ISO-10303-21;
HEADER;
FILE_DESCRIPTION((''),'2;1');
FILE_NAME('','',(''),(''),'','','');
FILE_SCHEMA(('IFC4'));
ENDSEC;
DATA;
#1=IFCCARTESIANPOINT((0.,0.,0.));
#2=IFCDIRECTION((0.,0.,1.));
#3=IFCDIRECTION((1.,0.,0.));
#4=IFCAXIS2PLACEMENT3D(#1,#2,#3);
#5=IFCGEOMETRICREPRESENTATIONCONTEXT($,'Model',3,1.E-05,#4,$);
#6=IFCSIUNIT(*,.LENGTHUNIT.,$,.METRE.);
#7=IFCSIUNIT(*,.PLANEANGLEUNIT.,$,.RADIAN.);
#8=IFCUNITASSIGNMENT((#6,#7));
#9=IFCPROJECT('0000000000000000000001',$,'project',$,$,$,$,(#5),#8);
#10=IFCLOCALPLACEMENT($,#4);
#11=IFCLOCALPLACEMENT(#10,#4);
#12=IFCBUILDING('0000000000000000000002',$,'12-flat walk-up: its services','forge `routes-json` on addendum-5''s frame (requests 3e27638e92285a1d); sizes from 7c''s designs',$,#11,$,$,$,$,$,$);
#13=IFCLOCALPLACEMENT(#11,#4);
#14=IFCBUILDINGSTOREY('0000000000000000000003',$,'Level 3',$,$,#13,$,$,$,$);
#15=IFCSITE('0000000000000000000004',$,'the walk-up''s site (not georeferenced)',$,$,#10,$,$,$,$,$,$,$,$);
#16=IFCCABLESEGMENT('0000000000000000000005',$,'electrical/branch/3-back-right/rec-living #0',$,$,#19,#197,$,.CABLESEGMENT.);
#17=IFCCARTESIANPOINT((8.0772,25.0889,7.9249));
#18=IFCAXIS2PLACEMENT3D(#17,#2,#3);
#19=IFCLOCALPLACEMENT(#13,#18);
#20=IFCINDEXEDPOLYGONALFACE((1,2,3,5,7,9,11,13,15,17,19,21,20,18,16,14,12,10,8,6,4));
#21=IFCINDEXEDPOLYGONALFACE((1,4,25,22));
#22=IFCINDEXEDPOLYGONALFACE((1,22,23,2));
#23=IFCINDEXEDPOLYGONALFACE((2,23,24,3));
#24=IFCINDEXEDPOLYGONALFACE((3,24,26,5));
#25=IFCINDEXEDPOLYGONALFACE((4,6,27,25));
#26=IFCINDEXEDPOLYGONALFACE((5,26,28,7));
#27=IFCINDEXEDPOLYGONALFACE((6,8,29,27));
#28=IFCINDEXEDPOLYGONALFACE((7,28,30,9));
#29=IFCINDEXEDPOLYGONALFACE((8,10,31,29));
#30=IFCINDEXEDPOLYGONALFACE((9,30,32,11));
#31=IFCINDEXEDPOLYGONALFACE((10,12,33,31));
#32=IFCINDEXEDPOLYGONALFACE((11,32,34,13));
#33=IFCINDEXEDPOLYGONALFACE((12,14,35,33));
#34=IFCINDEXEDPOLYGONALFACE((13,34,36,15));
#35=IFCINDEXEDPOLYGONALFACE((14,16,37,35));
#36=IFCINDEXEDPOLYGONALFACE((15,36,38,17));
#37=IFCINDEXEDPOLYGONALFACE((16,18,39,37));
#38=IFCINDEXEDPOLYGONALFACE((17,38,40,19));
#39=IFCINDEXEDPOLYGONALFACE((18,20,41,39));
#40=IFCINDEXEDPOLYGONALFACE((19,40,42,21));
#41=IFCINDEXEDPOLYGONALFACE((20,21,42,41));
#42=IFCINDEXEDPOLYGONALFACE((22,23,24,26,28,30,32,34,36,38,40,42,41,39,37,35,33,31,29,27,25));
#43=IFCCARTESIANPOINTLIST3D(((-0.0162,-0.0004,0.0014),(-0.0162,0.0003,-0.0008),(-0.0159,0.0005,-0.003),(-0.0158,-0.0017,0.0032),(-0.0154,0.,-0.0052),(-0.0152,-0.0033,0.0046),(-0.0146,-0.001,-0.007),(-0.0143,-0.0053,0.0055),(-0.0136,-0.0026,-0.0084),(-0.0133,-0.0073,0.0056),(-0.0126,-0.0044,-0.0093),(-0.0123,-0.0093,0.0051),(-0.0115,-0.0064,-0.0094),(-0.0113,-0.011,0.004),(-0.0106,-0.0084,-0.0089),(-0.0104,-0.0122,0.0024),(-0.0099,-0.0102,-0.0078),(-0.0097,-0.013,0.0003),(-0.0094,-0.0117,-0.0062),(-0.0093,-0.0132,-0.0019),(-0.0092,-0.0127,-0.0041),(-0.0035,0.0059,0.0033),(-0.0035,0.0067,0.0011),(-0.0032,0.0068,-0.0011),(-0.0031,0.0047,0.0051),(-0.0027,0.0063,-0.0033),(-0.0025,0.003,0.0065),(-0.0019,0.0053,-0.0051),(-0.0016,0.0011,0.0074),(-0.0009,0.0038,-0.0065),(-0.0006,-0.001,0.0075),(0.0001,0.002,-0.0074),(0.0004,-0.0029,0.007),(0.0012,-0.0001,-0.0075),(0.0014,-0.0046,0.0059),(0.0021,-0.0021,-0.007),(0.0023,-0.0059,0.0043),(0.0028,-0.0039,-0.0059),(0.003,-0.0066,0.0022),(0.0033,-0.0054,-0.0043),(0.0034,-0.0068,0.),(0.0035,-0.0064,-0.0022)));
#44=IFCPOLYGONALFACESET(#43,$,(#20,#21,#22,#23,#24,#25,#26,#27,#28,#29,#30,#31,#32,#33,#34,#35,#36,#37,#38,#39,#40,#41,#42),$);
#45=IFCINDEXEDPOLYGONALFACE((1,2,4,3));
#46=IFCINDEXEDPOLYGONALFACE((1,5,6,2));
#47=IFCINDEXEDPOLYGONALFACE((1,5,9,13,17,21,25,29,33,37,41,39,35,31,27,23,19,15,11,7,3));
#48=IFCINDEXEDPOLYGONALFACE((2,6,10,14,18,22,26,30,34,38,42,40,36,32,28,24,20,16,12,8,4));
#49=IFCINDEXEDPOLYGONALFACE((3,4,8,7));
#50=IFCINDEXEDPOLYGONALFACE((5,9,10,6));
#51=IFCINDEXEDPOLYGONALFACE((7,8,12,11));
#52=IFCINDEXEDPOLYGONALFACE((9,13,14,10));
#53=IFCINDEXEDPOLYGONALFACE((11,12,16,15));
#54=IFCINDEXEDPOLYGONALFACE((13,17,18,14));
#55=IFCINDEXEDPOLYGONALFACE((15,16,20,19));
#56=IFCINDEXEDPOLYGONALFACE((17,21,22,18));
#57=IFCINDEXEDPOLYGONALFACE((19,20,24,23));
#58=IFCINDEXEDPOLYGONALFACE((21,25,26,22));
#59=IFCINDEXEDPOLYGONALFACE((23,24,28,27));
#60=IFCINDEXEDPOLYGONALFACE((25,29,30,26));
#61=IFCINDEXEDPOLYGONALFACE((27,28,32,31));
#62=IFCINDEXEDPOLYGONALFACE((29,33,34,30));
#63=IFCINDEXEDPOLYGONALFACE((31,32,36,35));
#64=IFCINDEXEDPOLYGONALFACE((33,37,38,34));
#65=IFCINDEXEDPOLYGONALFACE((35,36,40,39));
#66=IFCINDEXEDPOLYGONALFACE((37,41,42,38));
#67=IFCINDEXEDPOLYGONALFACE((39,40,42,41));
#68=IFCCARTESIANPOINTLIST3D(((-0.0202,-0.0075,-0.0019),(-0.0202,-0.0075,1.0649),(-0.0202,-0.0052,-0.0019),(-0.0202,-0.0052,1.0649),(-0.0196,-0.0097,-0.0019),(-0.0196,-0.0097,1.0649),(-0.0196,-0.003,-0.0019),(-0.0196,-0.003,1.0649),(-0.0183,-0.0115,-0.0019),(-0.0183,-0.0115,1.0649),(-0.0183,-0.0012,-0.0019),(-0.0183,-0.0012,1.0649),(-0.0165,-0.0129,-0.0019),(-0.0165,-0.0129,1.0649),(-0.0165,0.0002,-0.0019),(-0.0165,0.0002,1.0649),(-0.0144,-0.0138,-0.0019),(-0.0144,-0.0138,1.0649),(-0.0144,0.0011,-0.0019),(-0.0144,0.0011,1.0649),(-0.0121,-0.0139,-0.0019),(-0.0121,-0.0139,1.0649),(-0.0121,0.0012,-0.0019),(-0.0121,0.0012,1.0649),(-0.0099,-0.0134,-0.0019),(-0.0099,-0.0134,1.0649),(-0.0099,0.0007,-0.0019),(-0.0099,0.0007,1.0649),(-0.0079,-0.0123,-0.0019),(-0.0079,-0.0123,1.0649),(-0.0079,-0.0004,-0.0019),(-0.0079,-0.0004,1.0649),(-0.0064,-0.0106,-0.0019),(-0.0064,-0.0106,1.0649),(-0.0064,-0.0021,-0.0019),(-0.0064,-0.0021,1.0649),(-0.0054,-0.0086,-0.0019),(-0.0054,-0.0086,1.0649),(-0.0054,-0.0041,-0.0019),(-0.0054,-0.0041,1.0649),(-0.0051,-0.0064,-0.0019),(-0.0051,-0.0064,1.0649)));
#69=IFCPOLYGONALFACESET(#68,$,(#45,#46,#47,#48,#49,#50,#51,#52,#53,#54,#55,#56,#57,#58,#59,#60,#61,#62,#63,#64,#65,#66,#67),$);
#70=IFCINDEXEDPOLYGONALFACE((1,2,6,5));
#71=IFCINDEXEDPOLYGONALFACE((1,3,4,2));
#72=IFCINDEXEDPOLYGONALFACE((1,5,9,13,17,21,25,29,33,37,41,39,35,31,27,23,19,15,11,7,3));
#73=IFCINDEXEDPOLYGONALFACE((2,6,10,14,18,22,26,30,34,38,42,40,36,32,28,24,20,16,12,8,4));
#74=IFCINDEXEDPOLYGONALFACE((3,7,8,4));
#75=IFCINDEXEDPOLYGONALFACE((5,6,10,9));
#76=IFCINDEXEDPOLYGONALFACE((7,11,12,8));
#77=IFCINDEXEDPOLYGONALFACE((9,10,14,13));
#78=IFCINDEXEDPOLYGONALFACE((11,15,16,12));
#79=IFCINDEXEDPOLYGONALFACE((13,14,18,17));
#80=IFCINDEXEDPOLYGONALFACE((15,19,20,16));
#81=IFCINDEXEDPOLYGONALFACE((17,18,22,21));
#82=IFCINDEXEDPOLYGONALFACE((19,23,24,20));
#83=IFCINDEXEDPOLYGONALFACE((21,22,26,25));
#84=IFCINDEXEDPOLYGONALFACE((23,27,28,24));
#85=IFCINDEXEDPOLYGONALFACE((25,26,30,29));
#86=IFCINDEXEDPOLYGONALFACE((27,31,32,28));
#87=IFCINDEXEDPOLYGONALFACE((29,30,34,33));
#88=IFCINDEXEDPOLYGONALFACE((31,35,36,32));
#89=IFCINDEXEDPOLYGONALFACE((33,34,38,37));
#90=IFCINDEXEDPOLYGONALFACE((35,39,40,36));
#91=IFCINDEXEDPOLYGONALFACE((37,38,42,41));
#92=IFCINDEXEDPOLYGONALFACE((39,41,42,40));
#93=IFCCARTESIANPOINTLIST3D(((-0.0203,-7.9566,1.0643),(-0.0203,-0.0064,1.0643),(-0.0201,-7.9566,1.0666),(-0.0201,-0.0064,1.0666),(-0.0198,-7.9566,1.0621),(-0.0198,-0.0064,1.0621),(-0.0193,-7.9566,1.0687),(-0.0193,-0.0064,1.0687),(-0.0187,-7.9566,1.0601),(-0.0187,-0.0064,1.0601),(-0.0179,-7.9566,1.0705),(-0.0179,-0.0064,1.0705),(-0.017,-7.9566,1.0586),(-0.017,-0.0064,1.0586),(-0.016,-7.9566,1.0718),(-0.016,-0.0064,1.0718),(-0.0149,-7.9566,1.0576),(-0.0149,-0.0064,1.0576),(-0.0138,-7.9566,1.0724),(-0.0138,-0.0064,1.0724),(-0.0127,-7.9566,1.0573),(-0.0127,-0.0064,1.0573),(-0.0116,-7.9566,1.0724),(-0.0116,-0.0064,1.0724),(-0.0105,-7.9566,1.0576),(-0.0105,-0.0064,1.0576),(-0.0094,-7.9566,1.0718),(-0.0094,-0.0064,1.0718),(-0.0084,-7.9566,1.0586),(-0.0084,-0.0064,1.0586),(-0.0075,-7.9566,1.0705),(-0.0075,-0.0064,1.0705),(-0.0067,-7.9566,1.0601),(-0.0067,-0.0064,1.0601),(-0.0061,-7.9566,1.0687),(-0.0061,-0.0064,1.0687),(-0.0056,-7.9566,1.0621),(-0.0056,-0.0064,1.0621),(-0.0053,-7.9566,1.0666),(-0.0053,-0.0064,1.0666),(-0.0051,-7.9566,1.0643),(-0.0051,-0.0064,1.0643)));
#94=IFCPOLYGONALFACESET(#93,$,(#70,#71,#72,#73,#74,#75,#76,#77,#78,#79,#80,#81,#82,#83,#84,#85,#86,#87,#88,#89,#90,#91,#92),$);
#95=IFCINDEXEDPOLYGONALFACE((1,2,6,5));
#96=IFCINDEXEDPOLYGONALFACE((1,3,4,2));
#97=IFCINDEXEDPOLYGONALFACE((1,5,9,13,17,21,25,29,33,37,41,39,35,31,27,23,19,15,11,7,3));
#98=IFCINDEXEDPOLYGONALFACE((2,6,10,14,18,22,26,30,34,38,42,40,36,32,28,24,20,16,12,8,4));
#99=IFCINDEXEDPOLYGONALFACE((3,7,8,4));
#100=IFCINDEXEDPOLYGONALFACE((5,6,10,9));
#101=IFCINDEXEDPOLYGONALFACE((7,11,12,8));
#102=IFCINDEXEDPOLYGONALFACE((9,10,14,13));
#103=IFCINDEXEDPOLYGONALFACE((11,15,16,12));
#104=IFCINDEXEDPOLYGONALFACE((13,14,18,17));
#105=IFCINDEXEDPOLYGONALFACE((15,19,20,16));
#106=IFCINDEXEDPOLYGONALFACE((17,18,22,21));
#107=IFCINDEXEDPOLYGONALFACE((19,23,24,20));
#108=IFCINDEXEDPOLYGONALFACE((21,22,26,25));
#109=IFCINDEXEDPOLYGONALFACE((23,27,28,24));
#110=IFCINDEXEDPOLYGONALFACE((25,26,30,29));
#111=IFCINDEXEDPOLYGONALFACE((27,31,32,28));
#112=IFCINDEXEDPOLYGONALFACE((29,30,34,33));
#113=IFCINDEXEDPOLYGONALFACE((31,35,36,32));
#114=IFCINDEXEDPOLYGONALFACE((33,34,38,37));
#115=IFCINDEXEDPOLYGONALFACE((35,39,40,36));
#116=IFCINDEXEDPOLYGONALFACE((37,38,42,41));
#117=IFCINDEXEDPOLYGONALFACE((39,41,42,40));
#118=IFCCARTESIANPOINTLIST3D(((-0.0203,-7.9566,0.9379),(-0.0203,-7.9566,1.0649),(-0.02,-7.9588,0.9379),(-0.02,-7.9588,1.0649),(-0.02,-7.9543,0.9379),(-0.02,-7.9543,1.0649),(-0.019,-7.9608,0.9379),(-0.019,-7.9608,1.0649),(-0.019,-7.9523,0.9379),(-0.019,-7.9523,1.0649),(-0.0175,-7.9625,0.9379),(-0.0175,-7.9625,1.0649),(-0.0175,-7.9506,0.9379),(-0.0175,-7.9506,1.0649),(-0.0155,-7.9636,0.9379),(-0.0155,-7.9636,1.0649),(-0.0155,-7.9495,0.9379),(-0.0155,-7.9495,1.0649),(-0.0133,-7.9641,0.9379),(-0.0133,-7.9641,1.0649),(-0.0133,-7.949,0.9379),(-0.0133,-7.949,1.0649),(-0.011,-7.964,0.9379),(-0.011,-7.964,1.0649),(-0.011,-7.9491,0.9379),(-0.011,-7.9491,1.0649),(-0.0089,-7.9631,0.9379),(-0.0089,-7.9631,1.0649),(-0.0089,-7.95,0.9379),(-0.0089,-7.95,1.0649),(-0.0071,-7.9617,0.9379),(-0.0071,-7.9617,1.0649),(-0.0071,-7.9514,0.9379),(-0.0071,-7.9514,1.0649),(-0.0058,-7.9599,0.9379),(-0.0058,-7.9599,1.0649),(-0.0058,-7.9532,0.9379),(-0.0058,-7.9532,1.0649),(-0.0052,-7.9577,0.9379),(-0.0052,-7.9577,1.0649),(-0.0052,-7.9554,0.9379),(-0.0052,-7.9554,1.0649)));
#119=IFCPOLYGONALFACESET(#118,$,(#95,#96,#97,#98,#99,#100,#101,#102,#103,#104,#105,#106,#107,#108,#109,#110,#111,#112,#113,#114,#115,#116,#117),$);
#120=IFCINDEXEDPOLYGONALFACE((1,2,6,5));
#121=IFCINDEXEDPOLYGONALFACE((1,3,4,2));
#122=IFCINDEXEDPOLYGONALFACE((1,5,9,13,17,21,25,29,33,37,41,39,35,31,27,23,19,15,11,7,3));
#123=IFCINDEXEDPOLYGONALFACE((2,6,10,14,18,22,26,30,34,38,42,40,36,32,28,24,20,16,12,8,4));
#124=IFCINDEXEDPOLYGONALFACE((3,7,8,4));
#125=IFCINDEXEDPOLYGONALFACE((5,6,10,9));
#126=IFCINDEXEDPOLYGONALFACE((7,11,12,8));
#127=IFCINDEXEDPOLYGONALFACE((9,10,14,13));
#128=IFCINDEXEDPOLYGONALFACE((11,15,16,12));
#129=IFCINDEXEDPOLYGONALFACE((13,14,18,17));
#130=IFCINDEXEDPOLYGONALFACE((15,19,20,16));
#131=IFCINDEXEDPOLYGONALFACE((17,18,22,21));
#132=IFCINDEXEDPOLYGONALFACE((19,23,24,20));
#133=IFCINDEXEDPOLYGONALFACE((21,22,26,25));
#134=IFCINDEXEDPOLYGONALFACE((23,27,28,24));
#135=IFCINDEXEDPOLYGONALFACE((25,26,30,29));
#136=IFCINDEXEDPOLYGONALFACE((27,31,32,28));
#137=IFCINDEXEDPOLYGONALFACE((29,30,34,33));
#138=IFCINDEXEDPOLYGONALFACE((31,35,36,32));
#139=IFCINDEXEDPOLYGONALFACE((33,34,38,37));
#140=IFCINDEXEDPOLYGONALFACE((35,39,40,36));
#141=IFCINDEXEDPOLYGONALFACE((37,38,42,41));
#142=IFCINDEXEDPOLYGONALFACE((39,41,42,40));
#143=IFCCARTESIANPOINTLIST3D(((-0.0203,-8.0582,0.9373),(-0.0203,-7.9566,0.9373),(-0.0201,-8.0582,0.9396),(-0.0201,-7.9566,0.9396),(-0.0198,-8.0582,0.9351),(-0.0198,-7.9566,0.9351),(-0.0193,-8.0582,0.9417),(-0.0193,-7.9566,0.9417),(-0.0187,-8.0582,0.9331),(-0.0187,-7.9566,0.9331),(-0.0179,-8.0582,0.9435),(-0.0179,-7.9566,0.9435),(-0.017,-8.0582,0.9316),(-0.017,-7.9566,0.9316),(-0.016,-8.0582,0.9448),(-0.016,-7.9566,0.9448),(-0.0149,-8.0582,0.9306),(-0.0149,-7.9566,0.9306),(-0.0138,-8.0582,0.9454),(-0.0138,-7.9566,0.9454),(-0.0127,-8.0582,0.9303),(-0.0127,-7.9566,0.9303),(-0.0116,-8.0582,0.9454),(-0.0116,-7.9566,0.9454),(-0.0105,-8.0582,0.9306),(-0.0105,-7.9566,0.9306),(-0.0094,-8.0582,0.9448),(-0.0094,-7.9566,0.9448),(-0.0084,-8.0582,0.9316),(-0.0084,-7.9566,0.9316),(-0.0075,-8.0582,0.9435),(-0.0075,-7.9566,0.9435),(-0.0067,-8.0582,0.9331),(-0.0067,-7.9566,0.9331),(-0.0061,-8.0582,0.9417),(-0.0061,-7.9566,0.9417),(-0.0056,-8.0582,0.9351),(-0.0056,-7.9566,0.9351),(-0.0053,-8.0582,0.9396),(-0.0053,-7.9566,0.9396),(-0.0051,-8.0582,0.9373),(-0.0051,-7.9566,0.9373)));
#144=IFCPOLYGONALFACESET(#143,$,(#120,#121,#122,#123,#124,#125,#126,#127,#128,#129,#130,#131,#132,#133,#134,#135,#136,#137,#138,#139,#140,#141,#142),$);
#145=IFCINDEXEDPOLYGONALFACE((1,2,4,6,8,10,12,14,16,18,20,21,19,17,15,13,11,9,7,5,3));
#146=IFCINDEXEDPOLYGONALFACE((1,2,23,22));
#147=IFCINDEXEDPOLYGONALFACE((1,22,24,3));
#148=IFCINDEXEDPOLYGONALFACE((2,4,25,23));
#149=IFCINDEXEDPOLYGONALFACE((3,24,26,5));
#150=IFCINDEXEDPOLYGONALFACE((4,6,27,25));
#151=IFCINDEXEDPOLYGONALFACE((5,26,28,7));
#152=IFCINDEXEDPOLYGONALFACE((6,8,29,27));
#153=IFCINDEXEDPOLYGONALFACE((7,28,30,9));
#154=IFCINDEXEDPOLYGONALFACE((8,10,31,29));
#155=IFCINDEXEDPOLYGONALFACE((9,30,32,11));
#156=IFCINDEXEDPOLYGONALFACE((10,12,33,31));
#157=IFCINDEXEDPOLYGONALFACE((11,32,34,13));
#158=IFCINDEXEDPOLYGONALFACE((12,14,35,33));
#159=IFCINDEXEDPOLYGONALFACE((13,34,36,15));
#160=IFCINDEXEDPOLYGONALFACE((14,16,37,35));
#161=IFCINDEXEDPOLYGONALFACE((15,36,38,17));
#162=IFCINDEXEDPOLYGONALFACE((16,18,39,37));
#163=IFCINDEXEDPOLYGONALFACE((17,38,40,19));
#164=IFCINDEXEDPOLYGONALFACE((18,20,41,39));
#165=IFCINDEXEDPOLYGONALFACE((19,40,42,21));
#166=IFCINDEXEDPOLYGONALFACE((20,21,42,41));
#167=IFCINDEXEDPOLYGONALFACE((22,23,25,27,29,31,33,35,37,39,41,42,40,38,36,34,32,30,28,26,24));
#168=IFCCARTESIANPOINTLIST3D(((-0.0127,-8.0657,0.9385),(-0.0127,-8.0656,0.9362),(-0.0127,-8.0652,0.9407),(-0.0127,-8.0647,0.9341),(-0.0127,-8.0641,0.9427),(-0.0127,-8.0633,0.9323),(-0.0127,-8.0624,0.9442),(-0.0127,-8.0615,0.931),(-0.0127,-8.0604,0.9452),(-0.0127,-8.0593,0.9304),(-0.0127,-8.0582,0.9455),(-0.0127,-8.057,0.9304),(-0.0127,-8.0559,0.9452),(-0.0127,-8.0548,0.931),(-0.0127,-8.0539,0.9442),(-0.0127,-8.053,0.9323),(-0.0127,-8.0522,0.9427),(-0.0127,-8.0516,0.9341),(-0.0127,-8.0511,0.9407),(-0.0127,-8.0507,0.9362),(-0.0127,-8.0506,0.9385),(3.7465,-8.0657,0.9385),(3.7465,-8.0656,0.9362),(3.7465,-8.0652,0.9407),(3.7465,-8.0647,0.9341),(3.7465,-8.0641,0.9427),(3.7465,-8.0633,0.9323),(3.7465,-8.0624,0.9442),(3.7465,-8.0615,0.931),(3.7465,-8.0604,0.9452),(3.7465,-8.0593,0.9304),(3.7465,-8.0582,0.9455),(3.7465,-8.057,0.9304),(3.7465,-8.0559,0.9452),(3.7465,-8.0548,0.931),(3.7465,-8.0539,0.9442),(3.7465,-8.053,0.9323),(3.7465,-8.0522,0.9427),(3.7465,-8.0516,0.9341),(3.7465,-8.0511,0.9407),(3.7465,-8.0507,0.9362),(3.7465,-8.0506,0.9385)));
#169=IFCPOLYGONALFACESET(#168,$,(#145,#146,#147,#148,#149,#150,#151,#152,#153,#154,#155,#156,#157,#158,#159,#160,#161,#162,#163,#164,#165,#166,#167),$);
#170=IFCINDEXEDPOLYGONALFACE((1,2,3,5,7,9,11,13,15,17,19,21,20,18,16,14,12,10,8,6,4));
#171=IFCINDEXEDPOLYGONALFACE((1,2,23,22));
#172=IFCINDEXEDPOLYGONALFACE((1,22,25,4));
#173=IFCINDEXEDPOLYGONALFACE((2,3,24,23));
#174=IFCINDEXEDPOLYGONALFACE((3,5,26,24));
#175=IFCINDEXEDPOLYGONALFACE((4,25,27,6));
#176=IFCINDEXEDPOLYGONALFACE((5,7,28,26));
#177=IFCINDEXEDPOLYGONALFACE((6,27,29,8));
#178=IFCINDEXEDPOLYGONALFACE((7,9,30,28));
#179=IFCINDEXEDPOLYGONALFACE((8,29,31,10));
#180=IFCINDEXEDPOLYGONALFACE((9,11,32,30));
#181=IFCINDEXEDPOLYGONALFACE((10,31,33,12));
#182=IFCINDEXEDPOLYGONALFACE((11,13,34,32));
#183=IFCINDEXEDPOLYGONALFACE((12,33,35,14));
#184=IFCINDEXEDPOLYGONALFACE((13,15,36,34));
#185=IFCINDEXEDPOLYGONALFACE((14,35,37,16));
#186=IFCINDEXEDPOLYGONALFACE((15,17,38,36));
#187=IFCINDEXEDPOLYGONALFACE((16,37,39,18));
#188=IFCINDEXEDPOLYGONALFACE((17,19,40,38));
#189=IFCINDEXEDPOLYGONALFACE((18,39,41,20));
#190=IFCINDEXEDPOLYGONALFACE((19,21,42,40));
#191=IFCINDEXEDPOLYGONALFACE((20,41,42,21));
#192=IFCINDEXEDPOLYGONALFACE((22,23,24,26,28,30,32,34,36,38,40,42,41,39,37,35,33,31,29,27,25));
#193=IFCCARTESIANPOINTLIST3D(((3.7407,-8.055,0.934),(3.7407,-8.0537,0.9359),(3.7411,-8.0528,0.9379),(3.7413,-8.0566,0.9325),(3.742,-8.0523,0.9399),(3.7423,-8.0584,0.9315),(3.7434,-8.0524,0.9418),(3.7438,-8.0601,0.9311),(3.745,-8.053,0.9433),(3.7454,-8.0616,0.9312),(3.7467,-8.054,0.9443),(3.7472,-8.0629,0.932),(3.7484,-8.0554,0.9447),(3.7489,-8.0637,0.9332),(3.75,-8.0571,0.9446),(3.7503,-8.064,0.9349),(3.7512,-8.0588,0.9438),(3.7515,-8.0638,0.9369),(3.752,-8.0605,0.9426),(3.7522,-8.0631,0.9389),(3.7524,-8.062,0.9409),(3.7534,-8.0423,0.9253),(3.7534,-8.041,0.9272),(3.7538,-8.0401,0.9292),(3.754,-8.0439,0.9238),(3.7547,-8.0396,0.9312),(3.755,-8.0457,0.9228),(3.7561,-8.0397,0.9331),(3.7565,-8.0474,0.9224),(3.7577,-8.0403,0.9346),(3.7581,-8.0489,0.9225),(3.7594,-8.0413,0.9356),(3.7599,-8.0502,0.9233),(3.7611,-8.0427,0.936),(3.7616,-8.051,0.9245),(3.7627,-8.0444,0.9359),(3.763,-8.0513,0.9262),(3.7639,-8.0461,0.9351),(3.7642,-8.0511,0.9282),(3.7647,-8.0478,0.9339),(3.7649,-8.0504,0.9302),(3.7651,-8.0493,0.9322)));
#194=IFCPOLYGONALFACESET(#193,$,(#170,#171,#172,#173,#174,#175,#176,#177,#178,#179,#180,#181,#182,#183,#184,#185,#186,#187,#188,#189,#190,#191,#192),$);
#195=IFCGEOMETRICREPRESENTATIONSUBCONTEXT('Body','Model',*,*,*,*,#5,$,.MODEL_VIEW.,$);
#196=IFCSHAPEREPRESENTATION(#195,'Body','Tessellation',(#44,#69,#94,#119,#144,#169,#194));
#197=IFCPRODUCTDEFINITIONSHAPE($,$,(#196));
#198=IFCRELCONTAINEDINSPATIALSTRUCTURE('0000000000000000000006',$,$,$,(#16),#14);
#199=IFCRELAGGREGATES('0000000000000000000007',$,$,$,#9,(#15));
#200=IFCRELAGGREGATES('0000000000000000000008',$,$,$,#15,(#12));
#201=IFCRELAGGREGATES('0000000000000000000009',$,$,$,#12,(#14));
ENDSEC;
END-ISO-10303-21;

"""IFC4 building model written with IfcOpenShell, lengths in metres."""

from ifc_helpers import new_model, entity, si_unit, frame, origin_with_axes, place, context, subcontext, project, spatial, element, save


model = new_model("IFC4")

# Units and contexts
model_context = context("Model", 3, precision=1e-05, world=origin_with_axes())
body_context = subcontext(model_context, "Body", "Model", "MODEL_VIEW")
ifc_project = project(units=[si_unit("LENGTHUNIT", "METRE"), si_unit("PLANEANGLEUNIT", "RADIAN")], contexts=[model_context])

# Site, building, storey
site_placement = place(None, origin_with_axes())
site = spatial("IfcSite", under=ifc_project, at=site_placement, Name="the walk-up's site (not georeferenced)")
building_placement = place(site_placement, origin_with_axes())
building = spatial("IfcBuilding", under=site, at=building_placement, Name="12-flat walk-up: its services", Description="forge `routes-json` on addendum-5's frame (requests 3e27638e92285a1d); sizes from 7c's designs")
storey_placement = place(building_placement, origin_with_axes())
storey = spatial("IfcBuildingStorey", under=building, at=storey_placement, Name="Level 3")

# Cable segment
cable_segment_1_placement = place(storey_placement, frame((8.0772, 25.0889, 7.9249), z_axis=(0.0, 0.0, 1.0), x_axis=(1.0, 0.0, 0.0)))
element("IfcCableSegment", 1, at=cable_segment_1_placement, inside=storey, Name="electrical/branch/3-back-right/rec-living #0", PredefinedType="CABLESEGMENT", context=body_context, shape_type="AdvancedSweptSolid", body=[
    entity("IfcSweptDiskSolid", entity("IfcPolyline", [entity("IfcCartesianPoint", [0.0, 0.0, 0.0]), entity("IfcCartesianPoint", [-0.0127, -0.0064, -0.0019])]), 0.0076),
    entity("IfcSweptDiskSolid", entity("IfcPolyline", [entity("IfcCartesianPoint", [-0.0127, -0.0064, -0.0019]), entity("IfcCartesianPoint", [-0.0127, -0.0064, 1.0649])]), 0.0076),
    entity("IfcSweptDiskSolid", entity("IfcPolyline", [entity("IfcCartesianPoint", [-0.0127, -0.0064, 1.0649]), entity("IfcCartesianPoint", [-0.0127, -7.9566, 1.0649])]), 0.0076),
    entity("IfcSweptDiskSolid", entity("IfcPolyline", [entity("IfcCartesianPoint", [-0.0127, -7.9566, 1.0649]), entity("IfcCartesianPoint", [-0.0127, -7.9566, 0.9379])]), 0.0076),
    entity("IfcSweptDiskSolid", entity("IfcPolyline", [entity("IfcCartesianPoint", [-0.0127, -7.9566, 0.9379]), entity("IfcCartesianPoint", [-0.0127, -8.0582, 0.9379])]), 0.0076),
    entity("IfcSweptDiskSolid", entity("IfcPolyline", [entity("IfcCartesianPoint", [-0.0127, -8.0582, 0.9379]), entity("IfcCartesianPoint", [3.7465, -8.0582, 0.9379])]), 0.0076),
    entity("IfcSweptDiskSolid", entity("IfcPolyline", [entity("IfcCartesianPoint", [3.7465, -8.0582, 0.9379]), entity("IfcCartesianPoint", [3.7592, -8.0455, 0.9292])]), 0.0076),
])

save(model, "model.ifc")
